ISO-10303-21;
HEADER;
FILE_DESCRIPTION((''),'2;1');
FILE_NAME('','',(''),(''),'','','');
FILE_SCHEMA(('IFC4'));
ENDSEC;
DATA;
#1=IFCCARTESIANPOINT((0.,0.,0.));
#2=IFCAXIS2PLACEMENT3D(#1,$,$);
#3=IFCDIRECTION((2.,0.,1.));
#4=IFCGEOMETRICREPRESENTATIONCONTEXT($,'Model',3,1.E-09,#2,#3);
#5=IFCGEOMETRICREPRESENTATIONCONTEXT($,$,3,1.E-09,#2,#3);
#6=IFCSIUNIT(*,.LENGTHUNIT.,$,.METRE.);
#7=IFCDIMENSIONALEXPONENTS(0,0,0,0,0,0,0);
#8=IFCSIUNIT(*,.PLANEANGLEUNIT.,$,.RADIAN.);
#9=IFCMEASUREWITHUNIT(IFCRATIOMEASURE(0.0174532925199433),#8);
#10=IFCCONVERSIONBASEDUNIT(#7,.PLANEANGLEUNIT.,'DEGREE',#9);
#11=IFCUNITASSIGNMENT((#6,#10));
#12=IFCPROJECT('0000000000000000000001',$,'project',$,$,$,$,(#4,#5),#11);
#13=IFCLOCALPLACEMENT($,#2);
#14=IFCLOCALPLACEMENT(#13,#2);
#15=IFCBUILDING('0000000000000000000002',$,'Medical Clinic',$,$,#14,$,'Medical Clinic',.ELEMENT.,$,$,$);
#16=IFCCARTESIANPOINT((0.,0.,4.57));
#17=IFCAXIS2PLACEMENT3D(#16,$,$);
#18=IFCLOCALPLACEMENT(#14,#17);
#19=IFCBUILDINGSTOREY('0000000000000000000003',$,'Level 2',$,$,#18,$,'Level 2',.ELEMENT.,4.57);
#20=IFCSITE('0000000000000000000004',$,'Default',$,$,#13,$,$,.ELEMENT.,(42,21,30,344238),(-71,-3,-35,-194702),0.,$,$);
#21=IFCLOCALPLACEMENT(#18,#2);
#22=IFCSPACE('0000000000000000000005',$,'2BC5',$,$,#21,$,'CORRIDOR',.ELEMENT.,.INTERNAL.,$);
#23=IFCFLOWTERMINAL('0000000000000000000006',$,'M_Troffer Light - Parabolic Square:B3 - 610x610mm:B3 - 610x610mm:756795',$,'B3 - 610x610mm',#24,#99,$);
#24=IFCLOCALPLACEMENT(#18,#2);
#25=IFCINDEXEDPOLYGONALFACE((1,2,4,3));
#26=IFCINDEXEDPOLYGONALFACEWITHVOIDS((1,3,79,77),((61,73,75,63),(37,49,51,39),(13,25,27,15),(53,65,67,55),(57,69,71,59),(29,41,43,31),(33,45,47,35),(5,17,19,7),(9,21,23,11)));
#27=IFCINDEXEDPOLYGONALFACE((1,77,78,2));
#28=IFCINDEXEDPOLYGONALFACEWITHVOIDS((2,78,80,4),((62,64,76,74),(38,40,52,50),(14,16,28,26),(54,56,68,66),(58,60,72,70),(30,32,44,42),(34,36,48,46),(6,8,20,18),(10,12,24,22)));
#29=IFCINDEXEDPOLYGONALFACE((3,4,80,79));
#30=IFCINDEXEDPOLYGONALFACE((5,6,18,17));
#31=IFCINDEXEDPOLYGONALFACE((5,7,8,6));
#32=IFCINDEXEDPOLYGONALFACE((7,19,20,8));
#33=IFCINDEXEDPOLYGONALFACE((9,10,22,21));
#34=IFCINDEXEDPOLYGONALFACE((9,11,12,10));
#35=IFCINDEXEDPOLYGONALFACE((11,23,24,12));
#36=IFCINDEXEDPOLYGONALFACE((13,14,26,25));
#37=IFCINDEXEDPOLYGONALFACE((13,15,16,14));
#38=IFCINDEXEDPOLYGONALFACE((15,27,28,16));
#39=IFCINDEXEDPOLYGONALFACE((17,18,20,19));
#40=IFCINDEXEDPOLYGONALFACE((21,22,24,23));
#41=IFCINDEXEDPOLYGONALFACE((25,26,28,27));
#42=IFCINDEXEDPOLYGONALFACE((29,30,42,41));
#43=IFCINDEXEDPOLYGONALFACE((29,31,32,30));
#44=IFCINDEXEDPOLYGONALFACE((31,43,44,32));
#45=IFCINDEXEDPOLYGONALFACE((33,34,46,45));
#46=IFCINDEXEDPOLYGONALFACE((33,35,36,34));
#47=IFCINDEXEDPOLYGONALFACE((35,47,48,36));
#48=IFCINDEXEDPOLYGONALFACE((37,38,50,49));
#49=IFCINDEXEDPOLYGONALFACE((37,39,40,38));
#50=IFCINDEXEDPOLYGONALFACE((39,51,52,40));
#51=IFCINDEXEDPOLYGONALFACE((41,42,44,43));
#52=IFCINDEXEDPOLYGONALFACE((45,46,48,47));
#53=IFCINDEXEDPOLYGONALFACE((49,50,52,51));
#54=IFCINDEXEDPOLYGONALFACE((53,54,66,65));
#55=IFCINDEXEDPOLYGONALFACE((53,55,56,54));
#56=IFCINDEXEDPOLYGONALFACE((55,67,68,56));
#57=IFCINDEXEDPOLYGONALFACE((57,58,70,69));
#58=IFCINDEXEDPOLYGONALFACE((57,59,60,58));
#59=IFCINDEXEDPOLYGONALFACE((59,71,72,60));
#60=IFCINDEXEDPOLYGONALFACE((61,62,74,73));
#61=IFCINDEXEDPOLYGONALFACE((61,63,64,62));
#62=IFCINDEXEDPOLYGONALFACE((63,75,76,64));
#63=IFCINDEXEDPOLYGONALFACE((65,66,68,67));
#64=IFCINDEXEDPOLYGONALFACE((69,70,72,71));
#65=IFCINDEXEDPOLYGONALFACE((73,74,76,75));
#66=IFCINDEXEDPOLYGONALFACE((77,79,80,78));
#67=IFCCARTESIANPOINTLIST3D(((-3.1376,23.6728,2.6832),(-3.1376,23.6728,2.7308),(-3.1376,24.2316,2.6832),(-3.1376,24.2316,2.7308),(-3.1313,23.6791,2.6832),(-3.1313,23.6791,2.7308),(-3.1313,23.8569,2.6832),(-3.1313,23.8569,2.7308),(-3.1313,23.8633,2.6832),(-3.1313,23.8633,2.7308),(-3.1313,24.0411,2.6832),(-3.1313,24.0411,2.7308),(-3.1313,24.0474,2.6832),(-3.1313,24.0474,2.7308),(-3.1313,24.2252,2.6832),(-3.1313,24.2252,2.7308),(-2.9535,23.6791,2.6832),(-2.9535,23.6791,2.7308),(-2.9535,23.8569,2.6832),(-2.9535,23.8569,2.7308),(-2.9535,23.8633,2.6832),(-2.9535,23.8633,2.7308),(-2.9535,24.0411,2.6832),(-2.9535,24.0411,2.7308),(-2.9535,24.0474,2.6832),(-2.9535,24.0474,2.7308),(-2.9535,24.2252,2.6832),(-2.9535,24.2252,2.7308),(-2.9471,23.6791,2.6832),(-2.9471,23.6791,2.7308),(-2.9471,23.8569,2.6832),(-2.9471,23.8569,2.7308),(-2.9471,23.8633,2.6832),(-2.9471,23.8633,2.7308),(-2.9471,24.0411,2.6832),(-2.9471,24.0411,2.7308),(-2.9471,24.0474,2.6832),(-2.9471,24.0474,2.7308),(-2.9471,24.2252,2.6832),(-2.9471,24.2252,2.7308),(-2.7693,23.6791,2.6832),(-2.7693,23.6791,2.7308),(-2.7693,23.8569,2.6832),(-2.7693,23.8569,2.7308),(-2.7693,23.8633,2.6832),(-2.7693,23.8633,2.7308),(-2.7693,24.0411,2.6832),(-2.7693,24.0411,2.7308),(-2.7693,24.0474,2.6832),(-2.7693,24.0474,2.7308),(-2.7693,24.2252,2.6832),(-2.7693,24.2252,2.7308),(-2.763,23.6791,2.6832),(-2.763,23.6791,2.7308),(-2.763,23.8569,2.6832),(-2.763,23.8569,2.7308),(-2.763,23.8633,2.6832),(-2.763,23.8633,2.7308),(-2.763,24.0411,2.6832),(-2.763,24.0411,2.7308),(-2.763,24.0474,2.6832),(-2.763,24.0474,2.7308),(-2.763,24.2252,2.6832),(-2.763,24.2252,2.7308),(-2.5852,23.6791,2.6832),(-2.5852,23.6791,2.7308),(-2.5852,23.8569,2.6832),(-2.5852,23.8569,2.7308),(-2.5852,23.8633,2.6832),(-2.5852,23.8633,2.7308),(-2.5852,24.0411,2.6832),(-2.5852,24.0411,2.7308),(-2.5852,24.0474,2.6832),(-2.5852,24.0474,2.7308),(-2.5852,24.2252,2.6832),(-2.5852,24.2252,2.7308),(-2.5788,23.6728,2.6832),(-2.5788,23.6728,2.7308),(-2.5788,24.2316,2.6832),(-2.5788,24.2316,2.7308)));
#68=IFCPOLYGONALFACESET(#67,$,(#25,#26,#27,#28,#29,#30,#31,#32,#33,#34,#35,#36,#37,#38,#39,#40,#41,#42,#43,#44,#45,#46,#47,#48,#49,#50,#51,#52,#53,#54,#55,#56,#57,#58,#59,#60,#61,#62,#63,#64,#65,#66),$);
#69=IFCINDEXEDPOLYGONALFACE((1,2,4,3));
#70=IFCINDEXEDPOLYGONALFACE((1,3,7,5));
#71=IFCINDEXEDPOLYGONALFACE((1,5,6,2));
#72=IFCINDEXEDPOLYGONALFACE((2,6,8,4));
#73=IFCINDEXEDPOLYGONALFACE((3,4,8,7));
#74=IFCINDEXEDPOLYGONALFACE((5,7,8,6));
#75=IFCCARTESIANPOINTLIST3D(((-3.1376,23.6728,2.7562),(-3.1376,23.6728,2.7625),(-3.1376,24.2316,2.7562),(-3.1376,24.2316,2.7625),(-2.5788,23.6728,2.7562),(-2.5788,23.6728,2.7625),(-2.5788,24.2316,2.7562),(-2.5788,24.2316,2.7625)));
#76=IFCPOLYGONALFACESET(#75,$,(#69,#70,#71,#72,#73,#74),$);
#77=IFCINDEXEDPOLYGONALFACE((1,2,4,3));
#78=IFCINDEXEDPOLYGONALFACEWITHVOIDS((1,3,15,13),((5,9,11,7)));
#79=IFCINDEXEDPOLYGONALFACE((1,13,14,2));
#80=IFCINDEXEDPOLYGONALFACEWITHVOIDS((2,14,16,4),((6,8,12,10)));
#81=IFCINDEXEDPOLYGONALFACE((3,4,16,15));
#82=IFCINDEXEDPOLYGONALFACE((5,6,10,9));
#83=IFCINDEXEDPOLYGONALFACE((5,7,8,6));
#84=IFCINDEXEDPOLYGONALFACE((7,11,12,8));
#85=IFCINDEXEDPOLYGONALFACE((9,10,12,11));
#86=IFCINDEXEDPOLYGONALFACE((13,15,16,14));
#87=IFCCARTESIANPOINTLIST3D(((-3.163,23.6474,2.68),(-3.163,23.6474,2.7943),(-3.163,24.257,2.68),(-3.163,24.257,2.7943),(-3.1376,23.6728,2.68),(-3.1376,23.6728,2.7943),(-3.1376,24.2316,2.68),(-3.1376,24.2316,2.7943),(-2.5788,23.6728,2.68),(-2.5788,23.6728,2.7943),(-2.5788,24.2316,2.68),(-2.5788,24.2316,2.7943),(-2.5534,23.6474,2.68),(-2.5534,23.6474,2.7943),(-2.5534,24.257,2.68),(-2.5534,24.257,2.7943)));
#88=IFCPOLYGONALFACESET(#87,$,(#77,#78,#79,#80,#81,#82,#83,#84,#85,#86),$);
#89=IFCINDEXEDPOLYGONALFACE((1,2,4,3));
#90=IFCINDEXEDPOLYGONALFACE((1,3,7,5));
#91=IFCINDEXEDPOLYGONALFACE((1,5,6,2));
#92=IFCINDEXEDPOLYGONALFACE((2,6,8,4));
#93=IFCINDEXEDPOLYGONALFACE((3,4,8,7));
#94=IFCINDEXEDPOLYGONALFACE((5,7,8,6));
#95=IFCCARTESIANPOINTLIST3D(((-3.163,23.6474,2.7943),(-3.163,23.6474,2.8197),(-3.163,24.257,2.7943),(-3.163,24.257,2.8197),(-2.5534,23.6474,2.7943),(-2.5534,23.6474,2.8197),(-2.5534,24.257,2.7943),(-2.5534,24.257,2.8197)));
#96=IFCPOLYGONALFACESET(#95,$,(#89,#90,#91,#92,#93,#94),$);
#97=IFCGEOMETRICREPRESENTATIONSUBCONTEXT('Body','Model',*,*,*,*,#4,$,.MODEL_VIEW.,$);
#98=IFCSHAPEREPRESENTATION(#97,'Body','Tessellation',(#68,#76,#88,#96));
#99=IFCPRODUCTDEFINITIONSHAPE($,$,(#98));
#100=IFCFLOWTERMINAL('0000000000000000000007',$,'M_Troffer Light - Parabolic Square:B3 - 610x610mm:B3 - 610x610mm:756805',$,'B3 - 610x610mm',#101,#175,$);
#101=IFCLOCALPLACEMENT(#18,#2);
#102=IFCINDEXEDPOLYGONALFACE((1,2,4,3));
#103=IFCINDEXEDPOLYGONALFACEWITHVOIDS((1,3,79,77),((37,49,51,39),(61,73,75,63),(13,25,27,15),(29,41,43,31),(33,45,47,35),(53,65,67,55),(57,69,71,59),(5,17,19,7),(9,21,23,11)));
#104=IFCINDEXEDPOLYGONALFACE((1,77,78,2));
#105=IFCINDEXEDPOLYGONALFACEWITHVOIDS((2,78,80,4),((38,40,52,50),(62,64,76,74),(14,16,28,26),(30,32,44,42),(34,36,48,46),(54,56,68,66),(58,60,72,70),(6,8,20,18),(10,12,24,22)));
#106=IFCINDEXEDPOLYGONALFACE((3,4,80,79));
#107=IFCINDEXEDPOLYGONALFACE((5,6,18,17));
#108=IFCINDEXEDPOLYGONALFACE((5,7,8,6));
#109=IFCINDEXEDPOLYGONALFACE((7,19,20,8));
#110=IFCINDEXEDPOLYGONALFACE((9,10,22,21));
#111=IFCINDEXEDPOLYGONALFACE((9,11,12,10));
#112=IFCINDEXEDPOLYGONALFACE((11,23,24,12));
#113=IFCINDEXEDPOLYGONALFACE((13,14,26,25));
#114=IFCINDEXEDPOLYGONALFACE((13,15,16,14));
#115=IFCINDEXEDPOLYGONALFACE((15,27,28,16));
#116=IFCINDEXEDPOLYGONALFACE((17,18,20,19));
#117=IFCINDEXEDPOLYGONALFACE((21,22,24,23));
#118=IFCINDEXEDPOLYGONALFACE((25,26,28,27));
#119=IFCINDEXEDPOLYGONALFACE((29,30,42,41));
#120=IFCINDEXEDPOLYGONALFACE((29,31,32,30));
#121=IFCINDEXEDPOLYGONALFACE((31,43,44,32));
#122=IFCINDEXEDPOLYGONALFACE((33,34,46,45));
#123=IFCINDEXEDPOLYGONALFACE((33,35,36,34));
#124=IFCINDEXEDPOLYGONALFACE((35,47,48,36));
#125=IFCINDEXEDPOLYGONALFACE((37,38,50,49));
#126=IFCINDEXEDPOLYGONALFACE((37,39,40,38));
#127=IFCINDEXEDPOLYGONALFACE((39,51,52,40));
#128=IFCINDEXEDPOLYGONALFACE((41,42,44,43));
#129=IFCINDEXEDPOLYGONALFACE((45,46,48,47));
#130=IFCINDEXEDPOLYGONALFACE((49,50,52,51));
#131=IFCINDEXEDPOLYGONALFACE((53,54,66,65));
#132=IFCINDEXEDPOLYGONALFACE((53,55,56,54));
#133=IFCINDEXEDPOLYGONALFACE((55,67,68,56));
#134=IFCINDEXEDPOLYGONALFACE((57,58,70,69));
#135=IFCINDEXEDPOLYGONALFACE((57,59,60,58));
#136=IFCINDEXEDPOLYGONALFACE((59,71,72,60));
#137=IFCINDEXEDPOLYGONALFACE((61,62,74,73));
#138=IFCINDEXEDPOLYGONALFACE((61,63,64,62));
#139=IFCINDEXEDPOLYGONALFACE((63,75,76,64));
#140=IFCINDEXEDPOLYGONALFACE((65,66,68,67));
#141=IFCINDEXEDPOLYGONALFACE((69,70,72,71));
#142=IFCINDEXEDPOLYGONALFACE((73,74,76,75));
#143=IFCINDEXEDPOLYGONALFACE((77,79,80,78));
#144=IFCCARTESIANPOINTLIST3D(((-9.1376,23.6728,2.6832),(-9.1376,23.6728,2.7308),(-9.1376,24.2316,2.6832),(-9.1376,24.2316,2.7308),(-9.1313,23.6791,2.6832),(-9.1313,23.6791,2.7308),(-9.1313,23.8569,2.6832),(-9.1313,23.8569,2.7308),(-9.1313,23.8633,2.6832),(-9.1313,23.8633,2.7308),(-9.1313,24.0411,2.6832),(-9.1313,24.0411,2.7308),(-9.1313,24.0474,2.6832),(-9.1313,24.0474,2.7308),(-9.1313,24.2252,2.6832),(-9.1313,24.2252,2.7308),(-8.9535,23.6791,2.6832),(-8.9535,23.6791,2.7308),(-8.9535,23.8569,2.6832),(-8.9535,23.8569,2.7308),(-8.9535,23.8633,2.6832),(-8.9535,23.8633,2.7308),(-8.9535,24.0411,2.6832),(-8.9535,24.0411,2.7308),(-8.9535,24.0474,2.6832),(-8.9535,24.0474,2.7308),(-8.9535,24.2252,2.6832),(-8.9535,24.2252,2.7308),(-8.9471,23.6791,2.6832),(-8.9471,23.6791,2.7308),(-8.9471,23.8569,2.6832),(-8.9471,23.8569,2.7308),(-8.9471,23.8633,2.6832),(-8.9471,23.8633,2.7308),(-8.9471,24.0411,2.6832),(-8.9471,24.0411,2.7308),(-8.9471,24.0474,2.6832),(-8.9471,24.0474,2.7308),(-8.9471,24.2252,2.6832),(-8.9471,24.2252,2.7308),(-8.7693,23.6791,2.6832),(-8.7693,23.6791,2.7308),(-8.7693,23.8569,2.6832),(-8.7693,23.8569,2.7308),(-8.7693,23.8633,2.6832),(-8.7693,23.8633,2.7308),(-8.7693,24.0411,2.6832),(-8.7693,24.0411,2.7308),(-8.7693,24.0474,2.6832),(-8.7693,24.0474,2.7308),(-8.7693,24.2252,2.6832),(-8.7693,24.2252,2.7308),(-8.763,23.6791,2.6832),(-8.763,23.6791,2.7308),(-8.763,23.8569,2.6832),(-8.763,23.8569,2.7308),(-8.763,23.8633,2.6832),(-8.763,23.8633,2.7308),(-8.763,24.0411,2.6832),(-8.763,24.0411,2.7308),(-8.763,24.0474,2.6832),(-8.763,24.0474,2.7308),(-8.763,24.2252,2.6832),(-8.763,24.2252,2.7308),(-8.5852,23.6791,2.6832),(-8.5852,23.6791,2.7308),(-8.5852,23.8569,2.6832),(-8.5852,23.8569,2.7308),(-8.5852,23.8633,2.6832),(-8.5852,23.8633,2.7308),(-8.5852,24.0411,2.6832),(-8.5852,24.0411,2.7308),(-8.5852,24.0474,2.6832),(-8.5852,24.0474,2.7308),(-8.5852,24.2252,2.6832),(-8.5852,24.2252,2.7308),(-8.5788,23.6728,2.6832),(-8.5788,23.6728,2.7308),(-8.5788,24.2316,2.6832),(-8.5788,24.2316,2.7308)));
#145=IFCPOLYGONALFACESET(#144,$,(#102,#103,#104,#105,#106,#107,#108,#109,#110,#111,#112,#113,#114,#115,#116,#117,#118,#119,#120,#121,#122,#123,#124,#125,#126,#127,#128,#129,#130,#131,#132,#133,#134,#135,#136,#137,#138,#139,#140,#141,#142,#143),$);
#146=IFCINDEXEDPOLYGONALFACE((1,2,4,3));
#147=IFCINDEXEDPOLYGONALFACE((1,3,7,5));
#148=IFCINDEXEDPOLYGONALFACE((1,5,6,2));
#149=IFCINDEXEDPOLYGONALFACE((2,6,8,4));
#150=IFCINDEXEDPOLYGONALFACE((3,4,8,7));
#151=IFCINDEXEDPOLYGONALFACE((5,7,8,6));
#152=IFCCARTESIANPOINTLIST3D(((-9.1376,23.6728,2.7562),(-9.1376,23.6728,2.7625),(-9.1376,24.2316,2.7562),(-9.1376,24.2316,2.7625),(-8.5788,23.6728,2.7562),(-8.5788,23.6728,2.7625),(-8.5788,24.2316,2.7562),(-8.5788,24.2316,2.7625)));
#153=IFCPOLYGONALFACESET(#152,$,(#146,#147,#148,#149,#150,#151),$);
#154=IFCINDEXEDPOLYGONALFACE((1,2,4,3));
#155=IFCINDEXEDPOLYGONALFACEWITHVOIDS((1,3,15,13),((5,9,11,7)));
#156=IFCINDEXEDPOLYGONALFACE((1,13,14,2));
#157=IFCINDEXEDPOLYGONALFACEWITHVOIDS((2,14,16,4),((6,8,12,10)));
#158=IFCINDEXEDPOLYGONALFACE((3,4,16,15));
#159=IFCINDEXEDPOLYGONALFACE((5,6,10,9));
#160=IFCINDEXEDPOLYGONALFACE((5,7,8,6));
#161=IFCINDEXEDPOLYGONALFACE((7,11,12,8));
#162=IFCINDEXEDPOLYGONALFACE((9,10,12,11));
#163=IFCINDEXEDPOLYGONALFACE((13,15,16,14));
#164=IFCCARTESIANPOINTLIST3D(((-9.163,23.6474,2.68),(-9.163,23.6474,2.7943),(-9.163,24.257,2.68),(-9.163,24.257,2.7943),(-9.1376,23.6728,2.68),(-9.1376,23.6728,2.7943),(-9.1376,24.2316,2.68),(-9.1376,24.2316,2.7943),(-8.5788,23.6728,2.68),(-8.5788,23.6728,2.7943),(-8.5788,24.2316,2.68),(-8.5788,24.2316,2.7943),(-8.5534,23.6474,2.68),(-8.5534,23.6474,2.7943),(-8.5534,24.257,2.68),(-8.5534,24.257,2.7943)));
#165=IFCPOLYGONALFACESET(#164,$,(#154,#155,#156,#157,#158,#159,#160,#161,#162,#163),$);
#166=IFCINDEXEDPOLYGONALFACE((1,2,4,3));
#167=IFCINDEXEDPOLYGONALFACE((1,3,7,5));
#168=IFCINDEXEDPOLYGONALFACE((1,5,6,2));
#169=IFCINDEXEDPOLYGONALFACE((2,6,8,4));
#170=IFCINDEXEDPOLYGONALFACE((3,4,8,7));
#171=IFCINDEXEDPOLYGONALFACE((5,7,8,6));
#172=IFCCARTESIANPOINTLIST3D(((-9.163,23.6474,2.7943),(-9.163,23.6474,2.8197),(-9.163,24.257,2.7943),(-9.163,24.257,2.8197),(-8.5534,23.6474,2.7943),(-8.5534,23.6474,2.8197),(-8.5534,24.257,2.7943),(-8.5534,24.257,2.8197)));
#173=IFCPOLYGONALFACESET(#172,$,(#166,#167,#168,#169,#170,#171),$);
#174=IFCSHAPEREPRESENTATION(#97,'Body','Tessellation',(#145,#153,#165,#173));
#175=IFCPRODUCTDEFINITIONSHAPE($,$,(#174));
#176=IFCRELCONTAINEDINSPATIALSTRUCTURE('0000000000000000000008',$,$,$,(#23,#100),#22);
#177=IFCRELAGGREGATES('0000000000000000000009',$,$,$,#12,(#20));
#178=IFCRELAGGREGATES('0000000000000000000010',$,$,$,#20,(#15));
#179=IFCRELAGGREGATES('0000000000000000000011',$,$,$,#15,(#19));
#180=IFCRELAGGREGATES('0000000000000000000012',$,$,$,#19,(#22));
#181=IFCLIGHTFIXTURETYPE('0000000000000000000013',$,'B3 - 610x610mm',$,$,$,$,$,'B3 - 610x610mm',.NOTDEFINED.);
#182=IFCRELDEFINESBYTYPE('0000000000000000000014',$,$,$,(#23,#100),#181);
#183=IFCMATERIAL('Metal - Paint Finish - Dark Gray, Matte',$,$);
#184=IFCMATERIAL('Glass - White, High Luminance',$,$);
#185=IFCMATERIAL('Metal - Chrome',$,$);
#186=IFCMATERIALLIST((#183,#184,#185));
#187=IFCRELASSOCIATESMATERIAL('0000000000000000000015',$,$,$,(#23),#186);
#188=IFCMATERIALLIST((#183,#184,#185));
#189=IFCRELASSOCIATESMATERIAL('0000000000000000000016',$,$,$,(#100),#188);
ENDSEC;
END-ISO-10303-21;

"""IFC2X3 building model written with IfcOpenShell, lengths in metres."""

from ifc_helpers import new_model, entity, si_unit, converted_unit, direction, frame, origin, origin_2d_with_axis, place, context, subcontext, project, spatial, polyline, rectangle, outline, extrude, source, transform, mapped, material, material_list, type_object, type_shapes, element, save


model = new_model("IFC2X3")

# Units and contexts
model_context = context("Model", 3, precision=1e-09, world=origin(), true_north=direction((2.0, 0.0, 1.0)))
context_of_model = context(None, 3, precision=1e-09, world=origin(), true_north=direction((2.0, 0.0, 1.0)))
body_context = subcontext(model_context, "Body", "Model", "MODEL_VIEW")
ifc_project = project(units=[si_unit("LENGTHUNIT", "METRE"), converted_unit("PLANEANGLEUNIT", "DEGREE", entity("IfcRatioMeasure", 0.0174532925199433), si_unit("PLANEANGLEUNIT", "RADIAN"), dimensions=[0, 0, 0, 0, 0, 0, 0])], contexts=[model_context, context_of_model])

# Site, building, storey, space
site_placement = place(None, origin())
site = spatial("IfcSite", under=ifc_project, at=site_placement, Name="Default", CompositionType="ELEMENT", RefLatitude=(42, 21, 30, 344238), RefLongitude=(-71, -3, -35, -194702), RefElevation=0.0)
building_placement = place(site_placement, origin())
building = spatial("IfcBuilding", under=site, at=building_placement, Name="Medical Clinic", LongName="Medical Clinic", CompositionType="ELEMENT")
storey_placement = place(building_placement, frame((0.0, 0.0, 4.57)))
storey = spatial("IfcBuildingStorey", under=building, at=storey_placement, Name="Level 2", LongName="Level 2", CompositionType="ELEMENT", Elevation=4.57)
space_1_placement = place(storey_placement, origin())
space_1 = spatial("IfcSpace", under=storey, at=space_1_placement, Name="2BC5", LongName="CORRIDOR", CompositionType="ELEMENT", InteriorOrExteriorSpace="INTERNAL")

# Flow terminals
ifc_material_1 = material(Name="Metal - Paint Finish - Dark Gray, Matte")
ifc_material_2 = material(Name="Glass - White, High Luminance")
ifc_material_3 = material(Name="Metal - Chrome")
ifc_material_list_1 = material_list([ifc_material_1, ifc_material_2, ifc_material_3])
light_fixture_type_1 = type_object("IfcLightFixtureType", Name="B3 - 610x610mm", ElementType="B3 - 610x610mm", PredefinedType="NOTDEFINED")
shared_shape_1 = source(origin(), body_context, "Body", "SweptSolid", [
    extrude(outline(polyline([(-0.2794, -0.2794), (0.2794, -0.2794), (0.2794, 0.2794), (-0.2794, 0.2794), (-0.2794, -0.2794)]), holes=[polyline([(-0.0952, 0.0953), (-0.273, 0.0953), (-0.273, 0.2731), (-0.0952, 0.2731), (-0.0952, 0.0953)]), polyline([(0.2731, 0.0953), (0.0953, 0.0953), (0.0953, 0.2731), (0.2731, 0.2731), (0.2731, 0.0953)]), polyline([(-0.0889, 0.2731), (0.0889, 0.2731), (0.0889, 0.0953), (-0.0889, 0.0953), (-0.0889, 0.2731)]), polyline([(0.2731, -0.273), (0.0953, -0.273), (0.0953, -0.0952), (0.2731, -0.0952), (0.2731, -0.273)]), polyline([(0.0889, -0.273), (-0.0889, -0.273), (-0.0889, -0.0952), (0.0889, -0.0952), (0.0889, -0.273)]), polyline([(-0.0952, -0.273), (-0.273, -0.273), (-0.273, -0.0952), (-0.0952, -0.0952), (-0.0952, -0.273)]), polyline([(-0.0952, -0.0889), (-0.273, -0.0889), (-0.273, 0.0889), (-0.0952, 0.0889), (-0.0952, -0.0889)]), polyline([(0.0889, -0.0889), (-0.0889, -0.0889), (-0.0889, 0.0889), (0.0889, 0.0889), (0.0889, -0.0889)]), polyline([(0.2731, -0.0889), (0.0953, -0.0889), (0.0953, 0.0889), (0.2731, 0.0889), (0.2731, -0.0889)])]), frame((0.0, -0.3048, -0.0508), z_axis=(0.0, 0.0, 1.0), x_axis=(-1.0, 0.0, 0.0)), (0.0, 0.0, 1.0), 0.0476),
    extrude(rectangle(XDim=0.5588, YDim=0.5588, at=origin_2d_with_axis()), frame((0.0, -0.3048, -0.0825), z_axis=(0.0, 0.0, 1.0), x_axis=(-1.0, 0.0, 0.0)), (0.0, 0.0, 1.0), 0.0064),
    extrude(outline(polyline([(-0.3048, -0.3048), (0.3048, -0.3048), (0.3048, 0.3048), (-0.3048, 0.3048), (-0.3048, -0.3048)]), holes=[polyline([(0.2794, 0.2794), (0.2794, -0.2794), (-0.2794, -0.2794), (-0.2794, 0.2794), (0.2794, 0.2794)])]), frame((0.0, -0.3048, -0.1143)), (0.0, 0.0, 1.0), 0.1143),
    extrude(rectangle(XDim=0.6096, YDim=0.6096, at=origin_2d_with_axis()), frame((0.0, -0.3048, -0.1397), z_axis=(0.0, 0.0, 1.0), x_axis=(-1.0, 0.0, 0.0)), (0.0, 0.0, 1.0), 0.0254),
])
type_shapes(light_fixture_type_1, [shared_shape_1])
flow_terminal_1_placement = place(space_1_placement, frame((-2.8582, 23.6474, 2.68), z_axis=(0.0, 0.0, -1.0), x_axis=(1.0, 0.0, 0.0)))
element("IfcFlowTerminal", 1, at=flow_terminal_1_placement, inside=space_1, type_object=light_fixture_type_1, material=ifc_material_list_1, Name="M_Troffer Light - Parabolic Square:B3 - 610x610mm:B3 - 610x610mm:756795", ObjectType="B3 - 610x610mm", context=body_context, shape_type="MappedRepresentation", body=[
    mapped(shared_shape_1, transform((0.0, 0.0, 0.0), scale=1.0)),
])
ifc_material_list_2 = material_list([ifc_material_1, ifc_material_2, ifc_material_3])
flow_terminal_2_placement = place(space_1_placement, frame((-8.8582, 23.6474, 2.68), z_axis=(0.0, 0.0, -1.0), x_axis=(1.0, 0.0, 0.0)))
element("IfcFlowTerminal", 2, at=flow_terminal_2_placement, inside=space_1, type_object=light_fixture_type_1, material=ifc_material_list_2, Name="M_Troffer Light - Parabolic Square:B3 - 610x610mm:B3 - 610x610mm:756805", ObjectType="B3 - 610x610mm", context=body_context, shape_type="MappedRepresentation", body=[
    mapped(shared_shape_1, transform((0.0, 0.0, 0.0), scale=1.0)),
])

save(model, "model.ifc")
